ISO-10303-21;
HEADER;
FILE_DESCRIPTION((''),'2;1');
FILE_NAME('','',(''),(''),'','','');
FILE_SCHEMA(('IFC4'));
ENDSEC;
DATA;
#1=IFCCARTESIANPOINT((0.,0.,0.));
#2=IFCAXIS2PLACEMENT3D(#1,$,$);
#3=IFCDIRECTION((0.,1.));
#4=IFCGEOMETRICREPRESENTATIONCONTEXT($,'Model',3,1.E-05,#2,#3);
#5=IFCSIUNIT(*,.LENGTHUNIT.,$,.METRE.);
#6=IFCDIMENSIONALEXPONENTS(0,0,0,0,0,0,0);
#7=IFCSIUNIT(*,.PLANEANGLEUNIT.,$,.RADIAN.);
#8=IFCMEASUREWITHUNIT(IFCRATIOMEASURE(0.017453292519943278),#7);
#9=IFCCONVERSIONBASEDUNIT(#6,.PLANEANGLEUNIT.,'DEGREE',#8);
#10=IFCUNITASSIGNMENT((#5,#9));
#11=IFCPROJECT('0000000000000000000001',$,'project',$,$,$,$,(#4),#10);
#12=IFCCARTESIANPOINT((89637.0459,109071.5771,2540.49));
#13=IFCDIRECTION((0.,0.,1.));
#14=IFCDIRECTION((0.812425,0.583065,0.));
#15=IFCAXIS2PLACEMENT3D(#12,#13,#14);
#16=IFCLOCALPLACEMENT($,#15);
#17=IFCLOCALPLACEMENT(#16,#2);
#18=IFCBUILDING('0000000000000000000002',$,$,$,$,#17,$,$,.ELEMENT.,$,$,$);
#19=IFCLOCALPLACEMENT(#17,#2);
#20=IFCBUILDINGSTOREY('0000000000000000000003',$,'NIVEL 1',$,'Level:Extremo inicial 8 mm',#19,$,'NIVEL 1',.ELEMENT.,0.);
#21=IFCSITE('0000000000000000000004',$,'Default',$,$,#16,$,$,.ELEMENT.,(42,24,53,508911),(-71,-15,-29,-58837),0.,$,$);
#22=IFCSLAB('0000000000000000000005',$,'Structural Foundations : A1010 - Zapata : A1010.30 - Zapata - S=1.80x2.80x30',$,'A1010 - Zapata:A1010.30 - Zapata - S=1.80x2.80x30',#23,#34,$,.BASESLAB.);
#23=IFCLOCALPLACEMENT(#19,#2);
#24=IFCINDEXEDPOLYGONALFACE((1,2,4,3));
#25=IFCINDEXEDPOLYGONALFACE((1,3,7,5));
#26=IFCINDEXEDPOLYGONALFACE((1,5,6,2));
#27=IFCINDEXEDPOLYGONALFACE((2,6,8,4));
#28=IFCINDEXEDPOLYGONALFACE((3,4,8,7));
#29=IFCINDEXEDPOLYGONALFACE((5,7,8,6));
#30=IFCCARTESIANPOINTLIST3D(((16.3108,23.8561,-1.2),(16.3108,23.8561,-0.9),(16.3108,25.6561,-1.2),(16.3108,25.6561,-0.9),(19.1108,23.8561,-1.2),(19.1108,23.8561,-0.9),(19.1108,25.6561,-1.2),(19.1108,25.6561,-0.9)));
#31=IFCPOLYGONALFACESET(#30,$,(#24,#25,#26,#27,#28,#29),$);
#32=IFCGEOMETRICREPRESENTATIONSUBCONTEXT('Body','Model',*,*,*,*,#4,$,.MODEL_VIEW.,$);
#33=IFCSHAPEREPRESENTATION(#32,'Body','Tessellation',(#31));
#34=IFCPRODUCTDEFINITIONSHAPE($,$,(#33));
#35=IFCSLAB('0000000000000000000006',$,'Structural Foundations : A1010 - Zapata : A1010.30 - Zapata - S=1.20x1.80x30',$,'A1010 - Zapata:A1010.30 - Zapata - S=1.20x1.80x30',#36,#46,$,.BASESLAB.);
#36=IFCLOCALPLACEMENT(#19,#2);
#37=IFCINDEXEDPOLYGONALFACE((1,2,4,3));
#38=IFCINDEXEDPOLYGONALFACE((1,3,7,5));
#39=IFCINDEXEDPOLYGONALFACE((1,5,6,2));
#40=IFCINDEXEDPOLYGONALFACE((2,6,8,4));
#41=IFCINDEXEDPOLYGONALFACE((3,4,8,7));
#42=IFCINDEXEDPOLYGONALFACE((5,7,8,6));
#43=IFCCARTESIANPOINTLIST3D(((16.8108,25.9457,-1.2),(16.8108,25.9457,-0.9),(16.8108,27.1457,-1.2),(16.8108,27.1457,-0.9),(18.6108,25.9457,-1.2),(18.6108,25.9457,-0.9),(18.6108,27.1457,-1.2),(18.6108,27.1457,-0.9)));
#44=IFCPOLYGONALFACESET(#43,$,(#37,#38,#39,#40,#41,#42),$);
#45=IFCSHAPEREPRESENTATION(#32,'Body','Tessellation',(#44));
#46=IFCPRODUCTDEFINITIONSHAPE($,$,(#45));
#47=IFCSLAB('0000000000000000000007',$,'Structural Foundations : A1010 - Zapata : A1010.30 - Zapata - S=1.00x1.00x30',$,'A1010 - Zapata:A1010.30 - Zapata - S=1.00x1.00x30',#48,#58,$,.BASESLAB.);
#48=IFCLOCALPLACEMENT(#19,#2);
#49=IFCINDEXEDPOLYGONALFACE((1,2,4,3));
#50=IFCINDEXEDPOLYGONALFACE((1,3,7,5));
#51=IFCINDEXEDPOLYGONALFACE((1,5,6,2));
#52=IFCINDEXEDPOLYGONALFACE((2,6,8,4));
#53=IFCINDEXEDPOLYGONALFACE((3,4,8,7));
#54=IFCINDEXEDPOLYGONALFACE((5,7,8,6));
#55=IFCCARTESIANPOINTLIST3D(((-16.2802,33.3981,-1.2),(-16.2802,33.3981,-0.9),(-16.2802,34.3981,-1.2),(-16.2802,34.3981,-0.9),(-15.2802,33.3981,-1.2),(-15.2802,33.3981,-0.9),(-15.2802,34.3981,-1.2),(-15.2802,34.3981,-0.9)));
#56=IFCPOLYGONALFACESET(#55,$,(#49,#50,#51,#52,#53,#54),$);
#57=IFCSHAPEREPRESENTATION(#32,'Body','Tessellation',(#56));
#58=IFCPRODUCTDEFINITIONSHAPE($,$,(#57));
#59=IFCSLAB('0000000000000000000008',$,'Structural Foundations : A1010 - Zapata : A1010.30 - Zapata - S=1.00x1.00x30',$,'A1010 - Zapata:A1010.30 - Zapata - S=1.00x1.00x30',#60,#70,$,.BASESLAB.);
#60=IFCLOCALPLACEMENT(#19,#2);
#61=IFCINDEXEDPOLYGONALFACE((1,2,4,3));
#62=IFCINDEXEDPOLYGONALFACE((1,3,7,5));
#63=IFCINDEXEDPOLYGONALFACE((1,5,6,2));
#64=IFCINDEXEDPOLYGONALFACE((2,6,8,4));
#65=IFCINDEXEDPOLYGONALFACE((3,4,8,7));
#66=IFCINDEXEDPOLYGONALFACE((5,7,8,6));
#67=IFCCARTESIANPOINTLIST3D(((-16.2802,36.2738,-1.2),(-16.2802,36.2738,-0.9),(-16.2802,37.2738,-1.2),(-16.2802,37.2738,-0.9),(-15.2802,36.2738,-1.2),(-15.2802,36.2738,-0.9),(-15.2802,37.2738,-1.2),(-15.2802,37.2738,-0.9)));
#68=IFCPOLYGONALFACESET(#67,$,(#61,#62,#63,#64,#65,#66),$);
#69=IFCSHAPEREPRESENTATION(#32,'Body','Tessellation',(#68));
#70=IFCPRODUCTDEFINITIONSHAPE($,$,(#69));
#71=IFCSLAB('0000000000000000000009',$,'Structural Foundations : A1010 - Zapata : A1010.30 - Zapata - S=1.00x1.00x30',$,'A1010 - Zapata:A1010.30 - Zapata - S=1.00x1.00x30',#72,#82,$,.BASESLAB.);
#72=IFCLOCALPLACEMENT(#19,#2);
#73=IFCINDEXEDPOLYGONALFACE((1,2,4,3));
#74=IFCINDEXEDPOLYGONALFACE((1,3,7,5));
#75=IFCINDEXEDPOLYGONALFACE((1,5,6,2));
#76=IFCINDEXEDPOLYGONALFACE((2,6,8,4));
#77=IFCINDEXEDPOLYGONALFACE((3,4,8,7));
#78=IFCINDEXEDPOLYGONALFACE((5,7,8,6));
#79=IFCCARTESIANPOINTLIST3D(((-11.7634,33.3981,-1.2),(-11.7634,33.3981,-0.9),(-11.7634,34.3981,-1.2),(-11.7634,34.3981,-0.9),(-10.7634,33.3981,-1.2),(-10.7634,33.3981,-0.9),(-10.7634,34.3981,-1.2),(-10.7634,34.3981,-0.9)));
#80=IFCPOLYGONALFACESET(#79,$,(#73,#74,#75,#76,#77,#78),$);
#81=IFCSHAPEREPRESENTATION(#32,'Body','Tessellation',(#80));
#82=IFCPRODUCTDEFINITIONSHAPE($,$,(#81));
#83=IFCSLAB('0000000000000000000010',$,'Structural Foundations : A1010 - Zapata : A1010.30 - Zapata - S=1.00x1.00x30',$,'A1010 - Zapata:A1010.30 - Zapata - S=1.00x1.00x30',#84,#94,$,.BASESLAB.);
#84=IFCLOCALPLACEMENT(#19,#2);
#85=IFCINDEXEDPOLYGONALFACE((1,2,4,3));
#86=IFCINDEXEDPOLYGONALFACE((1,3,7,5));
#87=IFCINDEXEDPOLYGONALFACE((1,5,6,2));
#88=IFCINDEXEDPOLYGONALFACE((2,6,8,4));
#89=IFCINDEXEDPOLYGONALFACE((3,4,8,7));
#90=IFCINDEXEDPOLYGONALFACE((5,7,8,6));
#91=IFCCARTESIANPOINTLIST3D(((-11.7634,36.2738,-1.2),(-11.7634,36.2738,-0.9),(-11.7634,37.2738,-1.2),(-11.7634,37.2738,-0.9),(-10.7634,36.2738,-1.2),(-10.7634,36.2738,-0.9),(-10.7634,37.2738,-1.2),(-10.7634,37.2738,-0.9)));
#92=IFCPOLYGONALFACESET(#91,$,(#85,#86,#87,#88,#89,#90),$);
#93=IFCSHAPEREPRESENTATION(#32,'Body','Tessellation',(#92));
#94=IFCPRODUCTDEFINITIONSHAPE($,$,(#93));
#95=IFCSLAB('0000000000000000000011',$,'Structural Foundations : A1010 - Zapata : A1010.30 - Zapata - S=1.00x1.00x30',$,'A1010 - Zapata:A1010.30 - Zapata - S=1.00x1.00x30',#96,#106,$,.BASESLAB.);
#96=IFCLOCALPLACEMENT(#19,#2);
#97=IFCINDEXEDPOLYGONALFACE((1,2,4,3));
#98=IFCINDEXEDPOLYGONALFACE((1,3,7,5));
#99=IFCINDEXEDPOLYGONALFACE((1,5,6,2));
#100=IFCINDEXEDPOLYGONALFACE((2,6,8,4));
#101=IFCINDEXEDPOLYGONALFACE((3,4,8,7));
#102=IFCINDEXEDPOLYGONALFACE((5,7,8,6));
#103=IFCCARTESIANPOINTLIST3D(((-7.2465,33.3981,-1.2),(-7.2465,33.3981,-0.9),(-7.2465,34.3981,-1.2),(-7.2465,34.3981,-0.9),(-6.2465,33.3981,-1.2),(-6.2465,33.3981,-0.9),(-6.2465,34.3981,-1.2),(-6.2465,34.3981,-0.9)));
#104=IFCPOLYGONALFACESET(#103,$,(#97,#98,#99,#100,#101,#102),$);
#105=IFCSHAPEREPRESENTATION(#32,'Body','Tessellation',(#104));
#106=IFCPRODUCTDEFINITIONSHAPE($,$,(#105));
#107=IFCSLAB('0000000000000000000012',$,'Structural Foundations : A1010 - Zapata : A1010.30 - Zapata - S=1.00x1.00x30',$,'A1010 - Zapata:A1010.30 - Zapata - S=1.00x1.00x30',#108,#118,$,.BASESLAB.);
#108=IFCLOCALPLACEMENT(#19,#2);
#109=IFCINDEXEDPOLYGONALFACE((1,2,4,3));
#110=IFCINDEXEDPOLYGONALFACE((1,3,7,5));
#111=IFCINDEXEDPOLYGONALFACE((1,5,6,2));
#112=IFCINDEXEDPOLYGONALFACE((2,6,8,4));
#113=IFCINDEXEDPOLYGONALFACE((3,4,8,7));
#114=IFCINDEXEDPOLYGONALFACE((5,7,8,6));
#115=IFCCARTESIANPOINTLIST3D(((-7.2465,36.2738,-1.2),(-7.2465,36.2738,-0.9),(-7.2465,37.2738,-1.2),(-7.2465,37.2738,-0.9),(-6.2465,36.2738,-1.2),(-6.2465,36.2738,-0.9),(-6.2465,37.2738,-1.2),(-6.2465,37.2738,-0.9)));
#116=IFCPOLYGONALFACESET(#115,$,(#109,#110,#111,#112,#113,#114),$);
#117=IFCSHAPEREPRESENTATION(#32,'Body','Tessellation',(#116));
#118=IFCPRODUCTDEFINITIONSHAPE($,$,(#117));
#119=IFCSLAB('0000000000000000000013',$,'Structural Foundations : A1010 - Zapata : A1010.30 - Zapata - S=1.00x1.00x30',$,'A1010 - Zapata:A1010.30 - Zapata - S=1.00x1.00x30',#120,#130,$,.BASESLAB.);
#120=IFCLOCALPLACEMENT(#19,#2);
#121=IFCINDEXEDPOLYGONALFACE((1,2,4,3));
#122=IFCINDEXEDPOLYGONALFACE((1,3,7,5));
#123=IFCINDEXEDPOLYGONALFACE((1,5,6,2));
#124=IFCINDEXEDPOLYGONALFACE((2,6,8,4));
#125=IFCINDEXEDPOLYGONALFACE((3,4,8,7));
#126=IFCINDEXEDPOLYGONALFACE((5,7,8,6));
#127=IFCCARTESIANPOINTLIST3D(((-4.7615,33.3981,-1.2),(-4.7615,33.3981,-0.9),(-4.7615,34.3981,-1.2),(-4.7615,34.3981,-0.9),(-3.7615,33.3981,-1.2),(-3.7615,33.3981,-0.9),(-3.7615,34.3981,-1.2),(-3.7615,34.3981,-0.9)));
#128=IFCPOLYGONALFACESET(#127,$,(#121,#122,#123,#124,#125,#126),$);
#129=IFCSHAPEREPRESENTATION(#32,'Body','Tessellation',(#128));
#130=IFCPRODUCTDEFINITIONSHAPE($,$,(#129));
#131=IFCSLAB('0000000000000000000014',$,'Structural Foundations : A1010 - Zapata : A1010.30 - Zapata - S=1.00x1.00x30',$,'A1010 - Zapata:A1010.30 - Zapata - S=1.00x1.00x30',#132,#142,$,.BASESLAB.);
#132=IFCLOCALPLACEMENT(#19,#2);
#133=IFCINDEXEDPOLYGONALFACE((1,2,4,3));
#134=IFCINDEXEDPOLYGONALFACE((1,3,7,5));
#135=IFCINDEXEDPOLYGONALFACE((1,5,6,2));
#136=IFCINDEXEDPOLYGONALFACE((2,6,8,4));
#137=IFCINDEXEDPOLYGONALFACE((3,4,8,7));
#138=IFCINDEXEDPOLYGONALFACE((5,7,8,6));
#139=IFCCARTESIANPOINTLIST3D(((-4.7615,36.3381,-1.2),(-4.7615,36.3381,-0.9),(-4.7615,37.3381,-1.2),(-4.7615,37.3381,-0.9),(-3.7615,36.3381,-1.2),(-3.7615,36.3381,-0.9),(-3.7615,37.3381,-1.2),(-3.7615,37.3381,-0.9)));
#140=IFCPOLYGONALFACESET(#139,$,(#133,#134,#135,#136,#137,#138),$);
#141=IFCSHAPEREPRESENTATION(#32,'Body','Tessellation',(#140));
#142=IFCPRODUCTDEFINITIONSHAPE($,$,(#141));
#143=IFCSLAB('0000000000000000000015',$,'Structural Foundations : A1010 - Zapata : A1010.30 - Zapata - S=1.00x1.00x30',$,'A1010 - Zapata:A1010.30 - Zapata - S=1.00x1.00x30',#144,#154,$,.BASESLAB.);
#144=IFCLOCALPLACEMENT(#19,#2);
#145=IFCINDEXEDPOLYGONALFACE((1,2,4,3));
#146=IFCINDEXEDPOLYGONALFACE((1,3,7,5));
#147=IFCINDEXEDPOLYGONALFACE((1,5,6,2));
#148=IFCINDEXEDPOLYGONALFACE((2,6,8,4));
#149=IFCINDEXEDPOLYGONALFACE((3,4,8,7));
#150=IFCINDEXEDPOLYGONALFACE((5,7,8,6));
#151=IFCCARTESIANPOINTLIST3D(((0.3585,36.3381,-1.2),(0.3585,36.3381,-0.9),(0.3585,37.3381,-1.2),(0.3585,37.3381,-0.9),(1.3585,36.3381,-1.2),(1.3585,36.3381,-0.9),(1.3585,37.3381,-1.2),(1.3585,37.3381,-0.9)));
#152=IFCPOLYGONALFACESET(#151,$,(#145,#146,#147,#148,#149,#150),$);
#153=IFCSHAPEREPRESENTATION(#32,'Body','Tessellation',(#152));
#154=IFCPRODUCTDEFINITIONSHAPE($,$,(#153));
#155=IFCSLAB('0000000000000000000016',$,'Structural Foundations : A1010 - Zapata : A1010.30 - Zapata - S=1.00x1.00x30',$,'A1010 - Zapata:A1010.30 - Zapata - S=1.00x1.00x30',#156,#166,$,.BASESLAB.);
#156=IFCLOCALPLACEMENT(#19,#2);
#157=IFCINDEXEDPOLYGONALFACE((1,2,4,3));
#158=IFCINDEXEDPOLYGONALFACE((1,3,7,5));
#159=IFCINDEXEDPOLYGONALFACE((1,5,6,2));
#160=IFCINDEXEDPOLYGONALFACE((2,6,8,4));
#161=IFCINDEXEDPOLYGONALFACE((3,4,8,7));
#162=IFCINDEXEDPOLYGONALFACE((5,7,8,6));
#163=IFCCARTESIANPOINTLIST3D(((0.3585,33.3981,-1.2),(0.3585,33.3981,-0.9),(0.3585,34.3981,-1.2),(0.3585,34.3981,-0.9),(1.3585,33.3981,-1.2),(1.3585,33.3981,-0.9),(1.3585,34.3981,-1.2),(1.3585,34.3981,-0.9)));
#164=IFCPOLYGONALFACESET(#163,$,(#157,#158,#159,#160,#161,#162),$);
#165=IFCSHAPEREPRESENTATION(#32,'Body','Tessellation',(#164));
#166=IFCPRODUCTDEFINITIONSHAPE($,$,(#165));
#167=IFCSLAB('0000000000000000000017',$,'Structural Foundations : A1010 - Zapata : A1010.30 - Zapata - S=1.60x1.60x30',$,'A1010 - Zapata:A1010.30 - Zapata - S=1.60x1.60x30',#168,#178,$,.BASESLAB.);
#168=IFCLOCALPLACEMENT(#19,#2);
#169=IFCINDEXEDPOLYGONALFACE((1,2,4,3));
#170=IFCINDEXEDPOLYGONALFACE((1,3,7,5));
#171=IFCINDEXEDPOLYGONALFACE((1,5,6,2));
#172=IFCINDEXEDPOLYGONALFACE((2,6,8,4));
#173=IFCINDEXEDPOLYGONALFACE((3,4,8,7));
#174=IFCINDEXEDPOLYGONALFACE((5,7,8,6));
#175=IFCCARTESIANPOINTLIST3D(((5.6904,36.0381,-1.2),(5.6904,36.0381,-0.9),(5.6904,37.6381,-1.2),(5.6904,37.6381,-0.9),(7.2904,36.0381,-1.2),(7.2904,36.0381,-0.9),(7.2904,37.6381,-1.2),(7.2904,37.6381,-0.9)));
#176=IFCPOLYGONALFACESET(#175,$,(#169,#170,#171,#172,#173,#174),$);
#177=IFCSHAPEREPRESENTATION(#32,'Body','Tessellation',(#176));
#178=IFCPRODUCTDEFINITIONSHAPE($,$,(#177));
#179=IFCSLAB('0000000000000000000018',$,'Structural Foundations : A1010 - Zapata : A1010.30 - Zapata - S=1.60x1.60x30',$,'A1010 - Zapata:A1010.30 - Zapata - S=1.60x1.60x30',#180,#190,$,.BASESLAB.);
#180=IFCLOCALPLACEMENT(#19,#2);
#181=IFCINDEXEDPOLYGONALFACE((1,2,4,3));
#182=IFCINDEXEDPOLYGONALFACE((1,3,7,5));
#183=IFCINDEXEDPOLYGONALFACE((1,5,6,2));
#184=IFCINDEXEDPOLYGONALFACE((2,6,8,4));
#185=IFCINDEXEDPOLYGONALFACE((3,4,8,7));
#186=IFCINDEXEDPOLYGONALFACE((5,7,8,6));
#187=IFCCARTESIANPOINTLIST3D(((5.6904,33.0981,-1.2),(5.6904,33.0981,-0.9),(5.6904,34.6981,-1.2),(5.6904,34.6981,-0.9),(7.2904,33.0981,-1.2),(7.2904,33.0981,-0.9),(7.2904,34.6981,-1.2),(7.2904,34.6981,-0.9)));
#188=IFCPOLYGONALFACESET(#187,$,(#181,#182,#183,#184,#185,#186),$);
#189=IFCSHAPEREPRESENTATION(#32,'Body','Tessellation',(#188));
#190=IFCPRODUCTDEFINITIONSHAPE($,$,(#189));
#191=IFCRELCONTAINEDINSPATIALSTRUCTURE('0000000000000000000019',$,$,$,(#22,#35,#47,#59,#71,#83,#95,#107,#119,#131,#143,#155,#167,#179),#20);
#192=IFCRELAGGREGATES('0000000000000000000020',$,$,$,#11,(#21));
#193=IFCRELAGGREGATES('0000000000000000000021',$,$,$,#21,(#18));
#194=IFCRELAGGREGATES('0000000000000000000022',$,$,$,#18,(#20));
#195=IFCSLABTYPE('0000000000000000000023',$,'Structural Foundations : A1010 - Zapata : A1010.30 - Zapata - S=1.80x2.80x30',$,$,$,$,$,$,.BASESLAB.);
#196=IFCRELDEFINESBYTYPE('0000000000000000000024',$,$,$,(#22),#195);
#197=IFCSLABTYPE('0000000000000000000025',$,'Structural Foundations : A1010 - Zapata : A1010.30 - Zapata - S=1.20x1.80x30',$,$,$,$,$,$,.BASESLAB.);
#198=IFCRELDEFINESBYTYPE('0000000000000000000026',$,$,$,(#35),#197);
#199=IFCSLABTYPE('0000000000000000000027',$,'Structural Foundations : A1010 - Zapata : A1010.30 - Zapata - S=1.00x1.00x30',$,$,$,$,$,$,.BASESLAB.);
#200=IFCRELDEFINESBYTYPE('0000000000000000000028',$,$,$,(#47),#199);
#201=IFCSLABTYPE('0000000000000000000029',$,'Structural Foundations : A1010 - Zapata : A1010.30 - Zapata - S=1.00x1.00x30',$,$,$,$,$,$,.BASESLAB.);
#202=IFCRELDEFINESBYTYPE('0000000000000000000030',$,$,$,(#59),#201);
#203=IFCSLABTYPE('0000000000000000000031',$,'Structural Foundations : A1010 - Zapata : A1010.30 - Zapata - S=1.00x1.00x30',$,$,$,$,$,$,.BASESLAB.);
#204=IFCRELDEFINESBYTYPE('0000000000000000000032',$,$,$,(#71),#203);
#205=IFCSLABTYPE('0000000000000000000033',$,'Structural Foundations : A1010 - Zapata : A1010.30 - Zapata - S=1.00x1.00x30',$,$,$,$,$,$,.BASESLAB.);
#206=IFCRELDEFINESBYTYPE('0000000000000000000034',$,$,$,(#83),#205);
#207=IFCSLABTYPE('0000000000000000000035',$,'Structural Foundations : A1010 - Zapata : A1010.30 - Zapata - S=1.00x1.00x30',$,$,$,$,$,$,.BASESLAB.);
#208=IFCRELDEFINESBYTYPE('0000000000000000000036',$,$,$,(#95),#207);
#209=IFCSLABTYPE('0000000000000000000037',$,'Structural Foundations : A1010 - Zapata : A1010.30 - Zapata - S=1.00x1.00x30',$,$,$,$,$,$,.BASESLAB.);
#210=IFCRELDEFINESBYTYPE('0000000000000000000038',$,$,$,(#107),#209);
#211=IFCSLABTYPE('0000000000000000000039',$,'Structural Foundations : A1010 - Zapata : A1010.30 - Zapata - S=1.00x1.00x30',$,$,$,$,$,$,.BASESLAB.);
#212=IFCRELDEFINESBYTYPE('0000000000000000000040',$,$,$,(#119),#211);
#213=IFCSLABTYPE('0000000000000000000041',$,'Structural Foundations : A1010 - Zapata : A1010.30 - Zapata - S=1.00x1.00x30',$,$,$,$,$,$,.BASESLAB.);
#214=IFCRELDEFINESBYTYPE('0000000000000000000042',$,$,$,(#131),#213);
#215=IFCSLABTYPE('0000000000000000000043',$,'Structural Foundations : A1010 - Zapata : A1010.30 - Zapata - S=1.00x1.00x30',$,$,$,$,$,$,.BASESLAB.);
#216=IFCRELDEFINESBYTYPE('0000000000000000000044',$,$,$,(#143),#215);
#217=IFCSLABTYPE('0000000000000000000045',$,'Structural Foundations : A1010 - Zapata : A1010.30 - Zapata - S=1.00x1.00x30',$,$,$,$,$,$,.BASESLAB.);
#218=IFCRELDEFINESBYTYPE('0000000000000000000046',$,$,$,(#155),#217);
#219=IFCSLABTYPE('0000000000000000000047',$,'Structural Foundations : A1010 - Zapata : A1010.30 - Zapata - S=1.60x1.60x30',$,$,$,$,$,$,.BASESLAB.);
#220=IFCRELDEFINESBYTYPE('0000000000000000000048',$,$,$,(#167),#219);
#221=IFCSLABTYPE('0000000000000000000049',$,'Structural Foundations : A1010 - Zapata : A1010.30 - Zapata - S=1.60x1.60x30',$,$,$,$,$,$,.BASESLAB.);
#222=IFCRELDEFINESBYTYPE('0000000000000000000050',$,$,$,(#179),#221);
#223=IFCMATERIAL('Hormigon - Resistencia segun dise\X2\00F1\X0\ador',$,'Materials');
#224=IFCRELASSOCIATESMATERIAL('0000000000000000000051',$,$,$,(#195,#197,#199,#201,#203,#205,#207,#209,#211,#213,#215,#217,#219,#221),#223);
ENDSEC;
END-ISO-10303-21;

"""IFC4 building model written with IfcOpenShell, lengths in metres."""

from ifc_helpers import new_model, entity, si_unit, converted_unit, direction, frame, frame_2d, origin, origin_2d_with_axis, place, context, subcontext, project, spatial, rectangle, extrude, material, type_object, element, save


model = new_model("IFC4")

# Units and contexts
model_context = context("Model", 3, precision=1e-05, world=origin(), true_north=direction((0.0, 1.0)))
body_context = subcontext(model_context, "Body", "Model", "MODEL_VIEW")
ifc_project = project(units=[si_unit("LENGTHUNIT", "METRE"), converted_unit("PLANEANGLEUNIT", "DEGREE", entity("IfcRatioMeasure", 0.017453292519943278), si_unit("PLANEANGLEUNIT", "RADIAN"), dimensions=[0, 0, 0, 0, 0, 0, 0])], contexts=[model_context])

# Site, building, storey
site_placement = place(None, frame((89637.0459, 109071.5771, 2540.49), z_axis=(0.0, 0.0, 1.0), x_axis=(0.812425, 0.583065, 0.0)))
site = spatial("IfcSite", under=ifc_project, at=site_placement, Name="Default", CompositionType="ELEMENT", RefLatitude=(42, 24, 53, 508911), RefLongitude=(-71, -15, -29, -58837), RefElevation=0.0)
building_placement = place(site_placement, origin())
building = spatial("IfcBuilding", under=site, at=building_placement, CompositionType="ELEMENT")
storey_placement = place(building_placement, origin())
storey = spatial("IfcBuildingStorey", under=building, at=storey_placement, Name="NIVEL 1", ObjectType="Level:Extremo inicial 8 mm", LongName="NIVEL 1", CompositionType="ELEMENT", Elevation=0.0)

# Slabs
ifc_material_1 = material(Name="Hormigon - Resistencia segun diseñador", Category="Materials")
slab_type_1 = type_object("IfcSlabType", Name="Structural Foundations : A1010 - Zapata : A1010.30 - Zapata - S=1.80x2.80x30", PredefinedType="BASESLAB", material=ifc_material_1)
slab_1_placement = place(storey_placement, frame((16.3108, 23.8561, -1.2)))
element("IfcSlab", 1, at=slab_1_placement, inside=storey, type_object=slab_type_1, Name="Structural Foundations : A1010 - Zapata : A1010.30 - Zapata - S=1.80x2.80x30", ObjectType="A1010 - Zapata:A1010.30 - Zapata - S=1.80x2.80x30", PredefinedType="BASESLAB", context=body_context, shape_type="SweptSolid", body=[
    extrude(rectangle(XDim=1.8, YDim=2.8, at=frame_2d((0.0, 0.0), x_axis=(1.0, 0.0))), frame((1.4, 0.9, 0.0), z_axis=(0.0, 0.0, 1.0), x_axis=(0.0, -1.0, 0.0)), (0.0, 0.0, 1.0), 0.3),
])
slab_type_2 = type_object("IfcSlabType", Name="Structural Foundations : A1010 - Zapata : A1010.30 - Zapata - S=1.20x1.80x30", PredefinedType="BASESLAB", material=ifc_material_1)
slab_2_placement = place(storey_placement, frame((16.8108, 25.9457, -1.2)))
element("IfcSlab", 2, at=slab_2_placement, inside=storey, type_object=slab_type_2, Name="Structural Foundations : A1010 - Zapata : A1010.30 - Zapata - S=1.20x1.80x30", ObjectType="A1010 - Zapata:A1010.30 - Zapata - S=1.20x1.80x30", PredefinedType="BASESLAB", context=body_context, shape_type="SweptSolid", body=[
    extrude(rectangle(XDim=1.2, YDim=1.8, at=origin_2d_with_axis()), frame((0.9, 0.6, 0.0), z_axis=(0.0, 0.0, 1.0), x_axis=(0.0, -1.0, 0.0)), (0.0, 0.0, 1.0), 0.3),
])
slab_type_3 = type_object("IfcSlabType", Name="Structural Foundations : A1010 - Zapata : A1010.30 - Zapata - S=1.00x1.00x30", PredefinedType="BASESLAB", material=ifc_material_1)
slab_3_placement = place(storey_placement, frame((-16.2802, 33.3981, -1.2)))
element("IfcSlab", 3, at=slab_3_placement, inside=storey, type_object=slab_type_3, Name="Structural Foundations : A1010 - Zapata : A1010.30 - Zapata - S=1.00x1.00x30", ObjectType="A1010 - Zapata:A1010.30 - Zapata - S=1.00x1.00x30", PredefinedType="BASESLAB", context=body_context, shape_type="SweptSolid", body=[
    extrude(rectangle(XDim=1.0, YDim=1.0, at=frame_2d((0.0, 0.0), x_axis=(1.0, 0.0))), frame((0.5, 0.5, 0.0), z_axis=(0.0, 0.0, 1.0), x_axis=(-1.0, 0.0, 0.0)), (0.0, 0.0, 1.0), 0.3),
])
slab_type_4 = type_object("IfcSlabType", Name="Structural Foundations : A1010 - Zapata : A1010.30 - Zapata - S=1.00x1.00x30", PredefinedType="BASESLAB", material=ifc_material_1)
slab_4_placement = place(storey_placement, frame((-16.2802, 36.2738, -1.2)))
element("IfcSlab", 4, at=slab_4_placement, inside=storey, type_object=slab_type_4, Name="Structural Foundations : A1010 - Zapata : A1010.30 - Zapata - S=1.00x1.00x30", ObjectType="A1010 - Zapata:A1010.30 - Zapata - S=1.00x1.00x30", PredefinedType="BASESLAB", context=body_context, shape_type="SweptSolid", body=[
    extrude(rectangle(XDim=1.0, YDim=1.0, at=frame_2d((0.0, 0.0), x_axis=(1.0, 0.0))), frame((0.5, 0.5, 0.0), z_axis=(0.0, 0.0, 1.0), x_axis=(-1.0, 0.0, 0.0)), (0.0, 0.0, 1.0), 0.3),
])
slab_type_5 = type_object("IfcSlabType", Name="Structural Foundations : A1010 - Zapata : A1010.30 - Zapata - S=1.00x1.00x30", PredefinedType="BASESLAB", material=ifc_material_1)
slab_5_placement = place(storey_placement, frame((-11.7634, 33.3981, -1.2)))
element("IfcSlab", 5, at=slab_5_placement, inside=storey, type_object=slab_type_5, Name="Structural Foundations : A1010 - Zapata : A1010.30 - Zapata - S=1.00x1.00x30", ObjectType="A1010 - Zapata:A1010.30 - Zapata - S=1.00x1.00x30", PredefinedType="BASESLAB", context=body_context, shape_type="SweptSolid", body=[
    extrude(rectangle(XDim=1.0, YDim=1.0, at=frame_2d((0.0, 0.0), x_axis=(1.0, 0.0))), frame((0.5, 0.5, 0.0), z_axis=(0.0, 0.0, 1.0), x_axis=(-1.0, 0.0, 0.0)), (0.0, 0.0, 1.0), 0.3),
])
slab_type_6 = type_object("IfcSlabType", Name="Structural Foundations : A1010 - Zapata : A1010.30 - Zapata - S=1.00x1.00x30", PredefinedType="BASESLAB", material=ifc_material_1)
slab_6_placement = place(storey_placement, frame((-11.7634, 36.2738, -1.2)))
element("IfcSlab", 6, at=slab_6_placement, inside=storey, type_object=slab_type_6, Name="Structural Foundations : A1010 - Zapata : A1010.30 - Zapata - S=1.00x1.00x30", ObjectType="A1010 - Zapata:A1010.30 - Zapata - S=1.00x1.00x30", PredefinedType="BASESLAB", context=body_context, shape_type="SweptSolid", body=[
    extrude(rectangle(XDim=1.0, YDim=1.0, at=frame_2d((0.0, 0.0), x_axis=(1.0, 0.0))), frame((0.5, 0.5, 0.0), z_axis=(0.0, 0.0, 1.0), x_axis=(-1.0, 0.0, 0.0)), (0.0, 0.0, 1.0), 0.3),
])
slab_type_7 = type_object("IfcSlabType", Name="Structural Foundations : A1010 - Zapata : A1010.30 - Zapata - S=1.00x1.00x30", PredefinedType="BASESLAB", material=ifc_material_1)
slab_7_placement = place(storey_placement, frame((-7.2465, 33.3981, -1.2)))
element("IfcSlab", 7, at=slab_7_placement, inside=storey, type_object=slab_type_7, Name="Structural Foundations : A1010 - Zapata : A1010.30 - Zapata - S=1.00x1.00x30", ObjectType="A1010 - Zapata:A1010.30 - Zapata - S=1.00x1.00x30", PredefinedType="BASESLAB", context=body_context, shape_type="SweptSolid", body=[
    extrude(rectangle(XDim=1.0, YDim=1.0, at=origin_2d_with_axis()), frame((0.5, 0.5, 0.0), z_axis=(0.0, 0.0, 1.0), x_axis=(-1.0, 0.0, 0.0)), (0.0, 0.0, 1.0), 0.3),
])
slab_type_8 = type_object("IfcSlabType", Name="Structural Foundations : A1010 - Zapata : A1010.30 - Zapata - S=1.00x1.00x30", PredefinedType="BASESLAB", material=ifc_material_1)
slab_8_placement = place(storey_placement, frame((-7.2465, 36.2738, -1.2)))
element("IfcSlab", 8, at=slab_8_placement, inside=storey, type_object=slab_type_8, Name="Structural Foundations : A1010 - Zapata : A1010.30 - Zapata - S=1.00x1.00x30", ObjectType="A1010 - Zapata:A1010.30 - Zapata - S=1.00x1.00x30", PredefinedType="BASESLAB", context=body_context, shape_type="SweptSolid", body=[
    extrude(rectangle(XDim=1.0, YDim=1.0, at=origin_2d_with_axis()), frame((0.5, 0.5, 0.0), z_axis=(0.0, 0.0, 1.0), x_axis=(-1.0, 0.0, 0.0)), (0.0, 0.0, 1.0), 0.3),
])
slab_type_9 = type_object("IfcSlabType", Name="Structural Foundations : A1010 - Zapata : A1010.30 - Zapata - S=1.00x1.00x30", PredefinedType="BASESLAB", material=ifc_material_1)
slab_9_placement = place(storey_placement, frame((-4.7615, 33.3981, -1.2)))
element("IfcSlab", 9, at=slab_9_placement, inside=storey, type_object=slab_type_9, Name="Structural Foundations : A1010 - Zapata : A1010.30 - Zapata - S=1.00x1.00x30", ObjectType="A1010 - Zapata:A1010.30 - Zapata - S=1.00x1.00x30", PredefinedType="BASESLAB", context=body_context, shape_type="SweptSolid", body=[
    extrude(rectangle(XDim=1.0, YDim=1.0, at=frame_2d((0.0, 0.0), x_axis=(1.0, 0.0))), frame((0.5, 0.5, 0.0), z_axis=(0.0, 0.0, 1.0), x_axis=(-1.0, 0.0, 0.0)), (0.0, 0.0, 1.0), 0.3),
])
slab_type_10 = type_object("IfcSlabType", Name="Structural Foundations : A1010 - Zapata : A1010.30 - Zapata - S=1.00x1.00x30", PredefinedType="BASESLAB", material=ifc_material_1)
slab_10_placement = place(storey_placement, frame((-4.7615, 36.3381, -1.2)))
element("IfcSlab", 10, at=slab_10_placement, inside=storey, type_object=slab_type_10, Name="Structural Foundations : A1010 - Zapata : A1010.30 - Zapata - S=1.00x1.00x30", ObjectType="A1010 - Zapata:A1010.30 - Zapata - S=1.00x1.00x30", PredefinedType="BASESLAB", context=body_context, shape_type="SweptSolid", body=[
    extrude(rectangle(XDim=1.0, YDim=1.0, at=frame_2d((0.0, 0.0), x_axis=(1.0, 0.0))), frame((0.5, 0.5, 0.0), z_axis=(0.0, 0.0, 1.0), x_axis=(-1.0, 0.0, 0.0)), (0.0, 0.0, 1.0), 0.3),
])
slab_type_11 = type_object("IfcSlabType", Name="Structural Foundations : A1010 - Zapata : A1010.30 - Zapata - S=1.00x1.00x30", PredefinedType="BASESLAB", material=ifc_material_1)
slab_11_placement = place(storey_placement, frame((0.3585, 36.3381, -1.2)))
element("IfcSlab", 11, at=slab_11_placement, inside=storey, type_object=slab_type_11, Name="Structural Foundations : A1010 - Zapata : A1010.30 - Zapata - S=1.00x1.00x30", ObjectType="A1010 - Zapata:A1010.30 - Zapata - S=1.00x1.00x30", PredefinedType="BASESLAB", context=body_context, shape_type="SweptSolid", body=[
    extrude(rectangle(XDim=1.0, YDim=1.0, at=frame_2d((0.0, 0.0), x_axis=(1.0, 0.0))), frame((0.5, 0.5, 0.0), z_axis=(0.0, 0.0, 1.0), x_axis=(-1.0, 0.0, 0.0)), (0.0, 0.0, 1.0), 0.3),
])
slab_type_12 = type_object("IfcSlabType", Name="Structural Foundations : A1010 - Zapata : A1010.30 - Zapata - S=1.00x1.00x30", PredefinedType="BASESLAB", material=ifc_material_1)
slab_12_placement = place(storey_placement, frame((0.3585, 33.3981, -1.2)))
element("IfcSlab", 12, at=slab_12_placement, inside=storey, type_object=slab_type_12, Name="Structural Foundations : A1010 - Zapata : A1010.30 - Zapata - S=1.00x1.00x30", ObjectType="A1010 - Zapata:A1010.30 - Zapata - S=1.00x1.00x30", PredefinedType="BASESLAB", context=body_context, shape_type="SweptSolid", body=[
    extrude(rectangle(XDim=1.0, YDim=1.0, at=frame_2d((0.0, 0.0), x_axis=(1.0, 0.0))), frame((0.5, 0.5, 0.0), z_axis=(0.0, 0.0, 1.0), x_axis=(-1.0, 0.0, 0.0)), (0.0, 0.0, 1.0), 0.3),
])
slab_type_13 = type_object("IfcSlabType", Name="Structural Foundations : A1010 - Zapata : A1010.30 - Zapata - S=1.60x1.60x30", PredefinedType="BASESLAB", material=ifc_material_1)
slab_13_placement = place(storey_placement, frame((5.6904, 36.0381, -1.2)))
element("IfcSlab", 13, at=slab_13_placement, inside=storey, type_object=slab_type_13, Name="Structural Foundations : A1010 - Zapata : A1010.30 - Zapata - S=1.60x1.60x30", ObjectType="A1010 - Zapata:A1010.30 - Zapata - S=1.60x1.60x30", PredefinedType="BASESLAB", context=body_context, shape_type="SweptSolid", body=[
    extrude(rectangle(XDim=1.6, YDim=1.6, at=origin_2d_with_axis()), frame((0.8, 0.8, 0.0), z_axis=(0.0, 0.0, 1.0), x_axis=(-1.0, 0.0, 0.0)), (0.0, 0.0, 1.0), 0.3),
])
slab_type_14 = type_object("IfcSlabType", Name="Structural Foundations : A1010 - Zapata : A1010.30 - Zapata - S=1.60x1.60x30", PredefinedType="BASESLAB", material=ifc_material_1)
slab_14_placement = place(storey_placement, frame((5.6904, 33.0981, -1.2)))
element("IfcSlab", 14, at=slab_14_placement, inside=storey, type_object=slab_type_14, Name="Structural Foundations : A1010 - Zapata : A1010.30 - Zapata - S=1.60x1.60x30", ObjectType="A1010 - Zapata:A1010.30 - Zapata - S=1.60x1.60x30", PredefinedType="BASESLAB", context=body_context, shape_type="SweptSolid", body=[
    extrude(rectangle(XDim=1.6, YDim=1.6, at=origin_2d_with_axis()), frame((0.8, 0.8, 0.0), z_axis=(0.0, 0.0, 1.0), x_axis=(-1.0, 0.0, 0.0)), (0.0, 0.0, 1.0), 0.3),
])

save(model, "model.ifc")
